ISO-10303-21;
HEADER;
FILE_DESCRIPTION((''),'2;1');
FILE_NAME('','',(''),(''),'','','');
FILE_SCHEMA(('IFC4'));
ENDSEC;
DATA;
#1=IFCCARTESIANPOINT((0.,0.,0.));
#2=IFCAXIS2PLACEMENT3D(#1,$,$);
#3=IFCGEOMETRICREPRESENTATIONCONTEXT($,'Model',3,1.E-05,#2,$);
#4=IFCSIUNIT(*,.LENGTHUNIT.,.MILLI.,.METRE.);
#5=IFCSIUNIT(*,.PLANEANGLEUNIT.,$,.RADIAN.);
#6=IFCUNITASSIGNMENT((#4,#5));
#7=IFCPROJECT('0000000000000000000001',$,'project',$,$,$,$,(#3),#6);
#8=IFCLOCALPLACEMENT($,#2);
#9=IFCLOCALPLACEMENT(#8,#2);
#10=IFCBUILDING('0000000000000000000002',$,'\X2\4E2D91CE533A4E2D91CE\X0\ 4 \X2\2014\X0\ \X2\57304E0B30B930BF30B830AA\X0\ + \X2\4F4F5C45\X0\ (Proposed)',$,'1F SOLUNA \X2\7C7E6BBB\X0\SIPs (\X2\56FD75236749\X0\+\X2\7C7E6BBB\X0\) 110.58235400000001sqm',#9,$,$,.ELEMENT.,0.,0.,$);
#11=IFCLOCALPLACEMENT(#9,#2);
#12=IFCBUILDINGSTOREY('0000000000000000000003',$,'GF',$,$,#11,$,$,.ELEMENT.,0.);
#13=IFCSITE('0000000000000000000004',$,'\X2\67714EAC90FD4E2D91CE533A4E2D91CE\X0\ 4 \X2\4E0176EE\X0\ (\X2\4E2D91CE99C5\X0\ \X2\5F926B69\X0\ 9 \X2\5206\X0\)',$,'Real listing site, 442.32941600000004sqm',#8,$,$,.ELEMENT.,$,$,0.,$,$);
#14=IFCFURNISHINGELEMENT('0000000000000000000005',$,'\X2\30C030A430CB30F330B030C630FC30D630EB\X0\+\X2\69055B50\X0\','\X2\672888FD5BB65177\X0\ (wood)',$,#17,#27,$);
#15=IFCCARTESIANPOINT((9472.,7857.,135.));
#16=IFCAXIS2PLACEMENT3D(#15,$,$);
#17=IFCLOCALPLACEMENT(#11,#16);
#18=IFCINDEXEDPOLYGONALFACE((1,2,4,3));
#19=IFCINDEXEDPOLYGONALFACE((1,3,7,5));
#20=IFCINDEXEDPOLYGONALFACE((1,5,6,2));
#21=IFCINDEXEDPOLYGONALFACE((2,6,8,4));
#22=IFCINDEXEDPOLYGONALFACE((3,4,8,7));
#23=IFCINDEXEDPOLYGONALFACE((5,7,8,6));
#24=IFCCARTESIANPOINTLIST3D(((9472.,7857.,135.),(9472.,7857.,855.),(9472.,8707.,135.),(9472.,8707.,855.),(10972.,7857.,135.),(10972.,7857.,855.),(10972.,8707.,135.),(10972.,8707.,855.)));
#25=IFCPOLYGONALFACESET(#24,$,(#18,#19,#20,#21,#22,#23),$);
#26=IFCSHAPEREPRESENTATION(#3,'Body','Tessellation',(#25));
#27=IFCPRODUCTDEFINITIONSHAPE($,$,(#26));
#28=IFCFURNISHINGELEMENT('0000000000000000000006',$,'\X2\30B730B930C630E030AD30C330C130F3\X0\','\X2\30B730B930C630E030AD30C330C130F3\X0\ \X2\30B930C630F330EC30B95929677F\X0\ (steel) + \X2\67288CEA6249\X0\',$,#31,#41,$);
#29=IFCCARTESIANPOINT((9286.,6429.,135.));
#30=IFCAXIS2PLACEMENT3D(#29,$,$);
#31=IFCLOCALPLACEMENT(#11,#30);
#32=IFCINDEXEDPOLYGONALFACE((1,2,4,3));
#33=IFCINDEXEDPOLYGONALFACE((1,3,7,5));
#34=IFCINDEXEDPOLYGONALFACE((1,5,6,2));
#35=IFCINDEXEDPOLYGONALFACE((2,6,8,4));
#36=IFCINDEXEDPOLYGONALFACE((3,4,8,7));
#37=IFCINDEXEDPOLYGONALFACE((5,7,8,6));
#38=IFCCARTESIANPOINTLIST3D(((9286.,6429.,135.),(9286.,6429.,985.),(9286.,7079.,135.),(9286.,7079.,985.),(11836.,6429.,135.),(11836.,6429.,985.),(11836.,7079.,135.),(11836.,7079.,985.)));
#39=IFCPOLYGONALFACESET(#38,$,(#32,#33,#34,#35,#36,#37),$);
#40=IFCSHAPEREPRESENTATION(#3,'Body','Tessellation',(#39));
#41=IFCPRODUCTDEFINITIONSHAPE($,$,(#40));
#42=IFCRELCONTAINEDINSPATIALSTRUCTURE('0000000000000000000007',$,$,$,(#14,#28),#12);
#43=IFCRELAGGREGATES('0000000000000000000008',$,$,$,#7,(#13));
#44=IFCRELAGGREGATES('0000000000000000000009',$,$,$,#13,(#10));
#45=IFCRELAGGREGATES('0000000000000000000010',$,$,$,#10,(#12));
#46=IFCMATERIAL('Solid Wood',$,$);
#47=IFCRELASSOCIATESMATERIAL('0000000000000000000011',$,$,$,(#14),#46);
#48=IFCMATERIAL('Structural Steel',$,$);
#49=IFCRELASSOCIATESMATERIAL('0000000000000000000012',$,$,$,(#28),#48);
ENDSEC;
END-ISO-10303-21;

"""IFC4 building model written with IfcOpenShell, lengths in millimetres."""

from ifc_helpers import new_model, si_unit, frame, frame_2d, origin, place, context, project, spatial, rectangle, extrude, material, element, save


model = new_model("IFC4")

# Units and contexts
model_context = context("Model", 3, precision=1e-05, world=origin())
ifc_project = project(units=[si_unit("LENGTHUNIT", "METRE", prefix="MILLI"), si_unit("PLANEANGLEUNIT", "RADIAN")], contexts=[model_context])

# Site, building, storey
site_placement = place(None, origin())
site = spatial("IfcSite", under=ifc_project, at=site_placement, Name="東京都中野区中野 4 丁目 (中野駅 徒歩 9 分)", ObjectType="Real listing site, 442.32941600000004sqm", CompositionType="ELEMENT", RefElevation=0.0)
building_placement = place(site_placement, origin())
building = spatial("IfcBuilding", under=site, at=building_placement, Name="中野区中野 4 — 地下スタジオ + 住居 (Proposed)", ObjectType="1F SOLUNA 籾殻SIPs (国産杉+籾殻) 110.58235400000001sqm", CompositionType="ELEMENT", ElevationOfRefHeight=0.0, ElevationOfTerrain=0.0)
storey_placement = place(building_placement, origin())
storey = spatial("IfcBuildingStorey", under=building, at=storey_placement, Name="GF", CompositionType="ELEMENT", Elevation=0.0)

# Shared definitions
ifc_material_1 = material(Name="Solid Wood")

# Shared definitions
ifc_material_2 = material(Name="Structural Steel")

# Furnishing elements
furnishing_1_placement = place(storey_placement, frame((9472.0, 7857.0, 135.0)))
element("IfcFurnishingElement", 1, at=furnishing_1_placement, inside=storey, material=ifc_material_1, Name="ダイニングテーブル+椅子", Description="木製家具 (wood)", context=model_context, shape_type="SweptSolid", body=[
    extrude(rectangle(XDim=1500.0, YDim=850.0, at=frame_2d((750.0, 425.0))), frame((9472.0, 7857.0, 135.0)), (0.0, 0.0, 1.0), 720.0),
])
furnishing_2_placement = place(storey_placement, frame((9286.0, 6429.0, 135.0)))
element("IfcFurnishingElement", 2, at=furnishing_2_placement, inside=storey, material=ifc_material_2, Name="システムキッチン", Description="システムキッチン ステンレス天板 (steel) + 木質扉", context=model_context, shape_type="SweptSolid", body=[
    extrude(rectangle(XDim=2550.0, YDim=650.0, at=frame_2d((1275.0, 325.0))), frame((9286.0, 6429.0, 135.0)), (0.0, 0.0, 1.0), 850.0),
])

save(model, "model.ifc")
